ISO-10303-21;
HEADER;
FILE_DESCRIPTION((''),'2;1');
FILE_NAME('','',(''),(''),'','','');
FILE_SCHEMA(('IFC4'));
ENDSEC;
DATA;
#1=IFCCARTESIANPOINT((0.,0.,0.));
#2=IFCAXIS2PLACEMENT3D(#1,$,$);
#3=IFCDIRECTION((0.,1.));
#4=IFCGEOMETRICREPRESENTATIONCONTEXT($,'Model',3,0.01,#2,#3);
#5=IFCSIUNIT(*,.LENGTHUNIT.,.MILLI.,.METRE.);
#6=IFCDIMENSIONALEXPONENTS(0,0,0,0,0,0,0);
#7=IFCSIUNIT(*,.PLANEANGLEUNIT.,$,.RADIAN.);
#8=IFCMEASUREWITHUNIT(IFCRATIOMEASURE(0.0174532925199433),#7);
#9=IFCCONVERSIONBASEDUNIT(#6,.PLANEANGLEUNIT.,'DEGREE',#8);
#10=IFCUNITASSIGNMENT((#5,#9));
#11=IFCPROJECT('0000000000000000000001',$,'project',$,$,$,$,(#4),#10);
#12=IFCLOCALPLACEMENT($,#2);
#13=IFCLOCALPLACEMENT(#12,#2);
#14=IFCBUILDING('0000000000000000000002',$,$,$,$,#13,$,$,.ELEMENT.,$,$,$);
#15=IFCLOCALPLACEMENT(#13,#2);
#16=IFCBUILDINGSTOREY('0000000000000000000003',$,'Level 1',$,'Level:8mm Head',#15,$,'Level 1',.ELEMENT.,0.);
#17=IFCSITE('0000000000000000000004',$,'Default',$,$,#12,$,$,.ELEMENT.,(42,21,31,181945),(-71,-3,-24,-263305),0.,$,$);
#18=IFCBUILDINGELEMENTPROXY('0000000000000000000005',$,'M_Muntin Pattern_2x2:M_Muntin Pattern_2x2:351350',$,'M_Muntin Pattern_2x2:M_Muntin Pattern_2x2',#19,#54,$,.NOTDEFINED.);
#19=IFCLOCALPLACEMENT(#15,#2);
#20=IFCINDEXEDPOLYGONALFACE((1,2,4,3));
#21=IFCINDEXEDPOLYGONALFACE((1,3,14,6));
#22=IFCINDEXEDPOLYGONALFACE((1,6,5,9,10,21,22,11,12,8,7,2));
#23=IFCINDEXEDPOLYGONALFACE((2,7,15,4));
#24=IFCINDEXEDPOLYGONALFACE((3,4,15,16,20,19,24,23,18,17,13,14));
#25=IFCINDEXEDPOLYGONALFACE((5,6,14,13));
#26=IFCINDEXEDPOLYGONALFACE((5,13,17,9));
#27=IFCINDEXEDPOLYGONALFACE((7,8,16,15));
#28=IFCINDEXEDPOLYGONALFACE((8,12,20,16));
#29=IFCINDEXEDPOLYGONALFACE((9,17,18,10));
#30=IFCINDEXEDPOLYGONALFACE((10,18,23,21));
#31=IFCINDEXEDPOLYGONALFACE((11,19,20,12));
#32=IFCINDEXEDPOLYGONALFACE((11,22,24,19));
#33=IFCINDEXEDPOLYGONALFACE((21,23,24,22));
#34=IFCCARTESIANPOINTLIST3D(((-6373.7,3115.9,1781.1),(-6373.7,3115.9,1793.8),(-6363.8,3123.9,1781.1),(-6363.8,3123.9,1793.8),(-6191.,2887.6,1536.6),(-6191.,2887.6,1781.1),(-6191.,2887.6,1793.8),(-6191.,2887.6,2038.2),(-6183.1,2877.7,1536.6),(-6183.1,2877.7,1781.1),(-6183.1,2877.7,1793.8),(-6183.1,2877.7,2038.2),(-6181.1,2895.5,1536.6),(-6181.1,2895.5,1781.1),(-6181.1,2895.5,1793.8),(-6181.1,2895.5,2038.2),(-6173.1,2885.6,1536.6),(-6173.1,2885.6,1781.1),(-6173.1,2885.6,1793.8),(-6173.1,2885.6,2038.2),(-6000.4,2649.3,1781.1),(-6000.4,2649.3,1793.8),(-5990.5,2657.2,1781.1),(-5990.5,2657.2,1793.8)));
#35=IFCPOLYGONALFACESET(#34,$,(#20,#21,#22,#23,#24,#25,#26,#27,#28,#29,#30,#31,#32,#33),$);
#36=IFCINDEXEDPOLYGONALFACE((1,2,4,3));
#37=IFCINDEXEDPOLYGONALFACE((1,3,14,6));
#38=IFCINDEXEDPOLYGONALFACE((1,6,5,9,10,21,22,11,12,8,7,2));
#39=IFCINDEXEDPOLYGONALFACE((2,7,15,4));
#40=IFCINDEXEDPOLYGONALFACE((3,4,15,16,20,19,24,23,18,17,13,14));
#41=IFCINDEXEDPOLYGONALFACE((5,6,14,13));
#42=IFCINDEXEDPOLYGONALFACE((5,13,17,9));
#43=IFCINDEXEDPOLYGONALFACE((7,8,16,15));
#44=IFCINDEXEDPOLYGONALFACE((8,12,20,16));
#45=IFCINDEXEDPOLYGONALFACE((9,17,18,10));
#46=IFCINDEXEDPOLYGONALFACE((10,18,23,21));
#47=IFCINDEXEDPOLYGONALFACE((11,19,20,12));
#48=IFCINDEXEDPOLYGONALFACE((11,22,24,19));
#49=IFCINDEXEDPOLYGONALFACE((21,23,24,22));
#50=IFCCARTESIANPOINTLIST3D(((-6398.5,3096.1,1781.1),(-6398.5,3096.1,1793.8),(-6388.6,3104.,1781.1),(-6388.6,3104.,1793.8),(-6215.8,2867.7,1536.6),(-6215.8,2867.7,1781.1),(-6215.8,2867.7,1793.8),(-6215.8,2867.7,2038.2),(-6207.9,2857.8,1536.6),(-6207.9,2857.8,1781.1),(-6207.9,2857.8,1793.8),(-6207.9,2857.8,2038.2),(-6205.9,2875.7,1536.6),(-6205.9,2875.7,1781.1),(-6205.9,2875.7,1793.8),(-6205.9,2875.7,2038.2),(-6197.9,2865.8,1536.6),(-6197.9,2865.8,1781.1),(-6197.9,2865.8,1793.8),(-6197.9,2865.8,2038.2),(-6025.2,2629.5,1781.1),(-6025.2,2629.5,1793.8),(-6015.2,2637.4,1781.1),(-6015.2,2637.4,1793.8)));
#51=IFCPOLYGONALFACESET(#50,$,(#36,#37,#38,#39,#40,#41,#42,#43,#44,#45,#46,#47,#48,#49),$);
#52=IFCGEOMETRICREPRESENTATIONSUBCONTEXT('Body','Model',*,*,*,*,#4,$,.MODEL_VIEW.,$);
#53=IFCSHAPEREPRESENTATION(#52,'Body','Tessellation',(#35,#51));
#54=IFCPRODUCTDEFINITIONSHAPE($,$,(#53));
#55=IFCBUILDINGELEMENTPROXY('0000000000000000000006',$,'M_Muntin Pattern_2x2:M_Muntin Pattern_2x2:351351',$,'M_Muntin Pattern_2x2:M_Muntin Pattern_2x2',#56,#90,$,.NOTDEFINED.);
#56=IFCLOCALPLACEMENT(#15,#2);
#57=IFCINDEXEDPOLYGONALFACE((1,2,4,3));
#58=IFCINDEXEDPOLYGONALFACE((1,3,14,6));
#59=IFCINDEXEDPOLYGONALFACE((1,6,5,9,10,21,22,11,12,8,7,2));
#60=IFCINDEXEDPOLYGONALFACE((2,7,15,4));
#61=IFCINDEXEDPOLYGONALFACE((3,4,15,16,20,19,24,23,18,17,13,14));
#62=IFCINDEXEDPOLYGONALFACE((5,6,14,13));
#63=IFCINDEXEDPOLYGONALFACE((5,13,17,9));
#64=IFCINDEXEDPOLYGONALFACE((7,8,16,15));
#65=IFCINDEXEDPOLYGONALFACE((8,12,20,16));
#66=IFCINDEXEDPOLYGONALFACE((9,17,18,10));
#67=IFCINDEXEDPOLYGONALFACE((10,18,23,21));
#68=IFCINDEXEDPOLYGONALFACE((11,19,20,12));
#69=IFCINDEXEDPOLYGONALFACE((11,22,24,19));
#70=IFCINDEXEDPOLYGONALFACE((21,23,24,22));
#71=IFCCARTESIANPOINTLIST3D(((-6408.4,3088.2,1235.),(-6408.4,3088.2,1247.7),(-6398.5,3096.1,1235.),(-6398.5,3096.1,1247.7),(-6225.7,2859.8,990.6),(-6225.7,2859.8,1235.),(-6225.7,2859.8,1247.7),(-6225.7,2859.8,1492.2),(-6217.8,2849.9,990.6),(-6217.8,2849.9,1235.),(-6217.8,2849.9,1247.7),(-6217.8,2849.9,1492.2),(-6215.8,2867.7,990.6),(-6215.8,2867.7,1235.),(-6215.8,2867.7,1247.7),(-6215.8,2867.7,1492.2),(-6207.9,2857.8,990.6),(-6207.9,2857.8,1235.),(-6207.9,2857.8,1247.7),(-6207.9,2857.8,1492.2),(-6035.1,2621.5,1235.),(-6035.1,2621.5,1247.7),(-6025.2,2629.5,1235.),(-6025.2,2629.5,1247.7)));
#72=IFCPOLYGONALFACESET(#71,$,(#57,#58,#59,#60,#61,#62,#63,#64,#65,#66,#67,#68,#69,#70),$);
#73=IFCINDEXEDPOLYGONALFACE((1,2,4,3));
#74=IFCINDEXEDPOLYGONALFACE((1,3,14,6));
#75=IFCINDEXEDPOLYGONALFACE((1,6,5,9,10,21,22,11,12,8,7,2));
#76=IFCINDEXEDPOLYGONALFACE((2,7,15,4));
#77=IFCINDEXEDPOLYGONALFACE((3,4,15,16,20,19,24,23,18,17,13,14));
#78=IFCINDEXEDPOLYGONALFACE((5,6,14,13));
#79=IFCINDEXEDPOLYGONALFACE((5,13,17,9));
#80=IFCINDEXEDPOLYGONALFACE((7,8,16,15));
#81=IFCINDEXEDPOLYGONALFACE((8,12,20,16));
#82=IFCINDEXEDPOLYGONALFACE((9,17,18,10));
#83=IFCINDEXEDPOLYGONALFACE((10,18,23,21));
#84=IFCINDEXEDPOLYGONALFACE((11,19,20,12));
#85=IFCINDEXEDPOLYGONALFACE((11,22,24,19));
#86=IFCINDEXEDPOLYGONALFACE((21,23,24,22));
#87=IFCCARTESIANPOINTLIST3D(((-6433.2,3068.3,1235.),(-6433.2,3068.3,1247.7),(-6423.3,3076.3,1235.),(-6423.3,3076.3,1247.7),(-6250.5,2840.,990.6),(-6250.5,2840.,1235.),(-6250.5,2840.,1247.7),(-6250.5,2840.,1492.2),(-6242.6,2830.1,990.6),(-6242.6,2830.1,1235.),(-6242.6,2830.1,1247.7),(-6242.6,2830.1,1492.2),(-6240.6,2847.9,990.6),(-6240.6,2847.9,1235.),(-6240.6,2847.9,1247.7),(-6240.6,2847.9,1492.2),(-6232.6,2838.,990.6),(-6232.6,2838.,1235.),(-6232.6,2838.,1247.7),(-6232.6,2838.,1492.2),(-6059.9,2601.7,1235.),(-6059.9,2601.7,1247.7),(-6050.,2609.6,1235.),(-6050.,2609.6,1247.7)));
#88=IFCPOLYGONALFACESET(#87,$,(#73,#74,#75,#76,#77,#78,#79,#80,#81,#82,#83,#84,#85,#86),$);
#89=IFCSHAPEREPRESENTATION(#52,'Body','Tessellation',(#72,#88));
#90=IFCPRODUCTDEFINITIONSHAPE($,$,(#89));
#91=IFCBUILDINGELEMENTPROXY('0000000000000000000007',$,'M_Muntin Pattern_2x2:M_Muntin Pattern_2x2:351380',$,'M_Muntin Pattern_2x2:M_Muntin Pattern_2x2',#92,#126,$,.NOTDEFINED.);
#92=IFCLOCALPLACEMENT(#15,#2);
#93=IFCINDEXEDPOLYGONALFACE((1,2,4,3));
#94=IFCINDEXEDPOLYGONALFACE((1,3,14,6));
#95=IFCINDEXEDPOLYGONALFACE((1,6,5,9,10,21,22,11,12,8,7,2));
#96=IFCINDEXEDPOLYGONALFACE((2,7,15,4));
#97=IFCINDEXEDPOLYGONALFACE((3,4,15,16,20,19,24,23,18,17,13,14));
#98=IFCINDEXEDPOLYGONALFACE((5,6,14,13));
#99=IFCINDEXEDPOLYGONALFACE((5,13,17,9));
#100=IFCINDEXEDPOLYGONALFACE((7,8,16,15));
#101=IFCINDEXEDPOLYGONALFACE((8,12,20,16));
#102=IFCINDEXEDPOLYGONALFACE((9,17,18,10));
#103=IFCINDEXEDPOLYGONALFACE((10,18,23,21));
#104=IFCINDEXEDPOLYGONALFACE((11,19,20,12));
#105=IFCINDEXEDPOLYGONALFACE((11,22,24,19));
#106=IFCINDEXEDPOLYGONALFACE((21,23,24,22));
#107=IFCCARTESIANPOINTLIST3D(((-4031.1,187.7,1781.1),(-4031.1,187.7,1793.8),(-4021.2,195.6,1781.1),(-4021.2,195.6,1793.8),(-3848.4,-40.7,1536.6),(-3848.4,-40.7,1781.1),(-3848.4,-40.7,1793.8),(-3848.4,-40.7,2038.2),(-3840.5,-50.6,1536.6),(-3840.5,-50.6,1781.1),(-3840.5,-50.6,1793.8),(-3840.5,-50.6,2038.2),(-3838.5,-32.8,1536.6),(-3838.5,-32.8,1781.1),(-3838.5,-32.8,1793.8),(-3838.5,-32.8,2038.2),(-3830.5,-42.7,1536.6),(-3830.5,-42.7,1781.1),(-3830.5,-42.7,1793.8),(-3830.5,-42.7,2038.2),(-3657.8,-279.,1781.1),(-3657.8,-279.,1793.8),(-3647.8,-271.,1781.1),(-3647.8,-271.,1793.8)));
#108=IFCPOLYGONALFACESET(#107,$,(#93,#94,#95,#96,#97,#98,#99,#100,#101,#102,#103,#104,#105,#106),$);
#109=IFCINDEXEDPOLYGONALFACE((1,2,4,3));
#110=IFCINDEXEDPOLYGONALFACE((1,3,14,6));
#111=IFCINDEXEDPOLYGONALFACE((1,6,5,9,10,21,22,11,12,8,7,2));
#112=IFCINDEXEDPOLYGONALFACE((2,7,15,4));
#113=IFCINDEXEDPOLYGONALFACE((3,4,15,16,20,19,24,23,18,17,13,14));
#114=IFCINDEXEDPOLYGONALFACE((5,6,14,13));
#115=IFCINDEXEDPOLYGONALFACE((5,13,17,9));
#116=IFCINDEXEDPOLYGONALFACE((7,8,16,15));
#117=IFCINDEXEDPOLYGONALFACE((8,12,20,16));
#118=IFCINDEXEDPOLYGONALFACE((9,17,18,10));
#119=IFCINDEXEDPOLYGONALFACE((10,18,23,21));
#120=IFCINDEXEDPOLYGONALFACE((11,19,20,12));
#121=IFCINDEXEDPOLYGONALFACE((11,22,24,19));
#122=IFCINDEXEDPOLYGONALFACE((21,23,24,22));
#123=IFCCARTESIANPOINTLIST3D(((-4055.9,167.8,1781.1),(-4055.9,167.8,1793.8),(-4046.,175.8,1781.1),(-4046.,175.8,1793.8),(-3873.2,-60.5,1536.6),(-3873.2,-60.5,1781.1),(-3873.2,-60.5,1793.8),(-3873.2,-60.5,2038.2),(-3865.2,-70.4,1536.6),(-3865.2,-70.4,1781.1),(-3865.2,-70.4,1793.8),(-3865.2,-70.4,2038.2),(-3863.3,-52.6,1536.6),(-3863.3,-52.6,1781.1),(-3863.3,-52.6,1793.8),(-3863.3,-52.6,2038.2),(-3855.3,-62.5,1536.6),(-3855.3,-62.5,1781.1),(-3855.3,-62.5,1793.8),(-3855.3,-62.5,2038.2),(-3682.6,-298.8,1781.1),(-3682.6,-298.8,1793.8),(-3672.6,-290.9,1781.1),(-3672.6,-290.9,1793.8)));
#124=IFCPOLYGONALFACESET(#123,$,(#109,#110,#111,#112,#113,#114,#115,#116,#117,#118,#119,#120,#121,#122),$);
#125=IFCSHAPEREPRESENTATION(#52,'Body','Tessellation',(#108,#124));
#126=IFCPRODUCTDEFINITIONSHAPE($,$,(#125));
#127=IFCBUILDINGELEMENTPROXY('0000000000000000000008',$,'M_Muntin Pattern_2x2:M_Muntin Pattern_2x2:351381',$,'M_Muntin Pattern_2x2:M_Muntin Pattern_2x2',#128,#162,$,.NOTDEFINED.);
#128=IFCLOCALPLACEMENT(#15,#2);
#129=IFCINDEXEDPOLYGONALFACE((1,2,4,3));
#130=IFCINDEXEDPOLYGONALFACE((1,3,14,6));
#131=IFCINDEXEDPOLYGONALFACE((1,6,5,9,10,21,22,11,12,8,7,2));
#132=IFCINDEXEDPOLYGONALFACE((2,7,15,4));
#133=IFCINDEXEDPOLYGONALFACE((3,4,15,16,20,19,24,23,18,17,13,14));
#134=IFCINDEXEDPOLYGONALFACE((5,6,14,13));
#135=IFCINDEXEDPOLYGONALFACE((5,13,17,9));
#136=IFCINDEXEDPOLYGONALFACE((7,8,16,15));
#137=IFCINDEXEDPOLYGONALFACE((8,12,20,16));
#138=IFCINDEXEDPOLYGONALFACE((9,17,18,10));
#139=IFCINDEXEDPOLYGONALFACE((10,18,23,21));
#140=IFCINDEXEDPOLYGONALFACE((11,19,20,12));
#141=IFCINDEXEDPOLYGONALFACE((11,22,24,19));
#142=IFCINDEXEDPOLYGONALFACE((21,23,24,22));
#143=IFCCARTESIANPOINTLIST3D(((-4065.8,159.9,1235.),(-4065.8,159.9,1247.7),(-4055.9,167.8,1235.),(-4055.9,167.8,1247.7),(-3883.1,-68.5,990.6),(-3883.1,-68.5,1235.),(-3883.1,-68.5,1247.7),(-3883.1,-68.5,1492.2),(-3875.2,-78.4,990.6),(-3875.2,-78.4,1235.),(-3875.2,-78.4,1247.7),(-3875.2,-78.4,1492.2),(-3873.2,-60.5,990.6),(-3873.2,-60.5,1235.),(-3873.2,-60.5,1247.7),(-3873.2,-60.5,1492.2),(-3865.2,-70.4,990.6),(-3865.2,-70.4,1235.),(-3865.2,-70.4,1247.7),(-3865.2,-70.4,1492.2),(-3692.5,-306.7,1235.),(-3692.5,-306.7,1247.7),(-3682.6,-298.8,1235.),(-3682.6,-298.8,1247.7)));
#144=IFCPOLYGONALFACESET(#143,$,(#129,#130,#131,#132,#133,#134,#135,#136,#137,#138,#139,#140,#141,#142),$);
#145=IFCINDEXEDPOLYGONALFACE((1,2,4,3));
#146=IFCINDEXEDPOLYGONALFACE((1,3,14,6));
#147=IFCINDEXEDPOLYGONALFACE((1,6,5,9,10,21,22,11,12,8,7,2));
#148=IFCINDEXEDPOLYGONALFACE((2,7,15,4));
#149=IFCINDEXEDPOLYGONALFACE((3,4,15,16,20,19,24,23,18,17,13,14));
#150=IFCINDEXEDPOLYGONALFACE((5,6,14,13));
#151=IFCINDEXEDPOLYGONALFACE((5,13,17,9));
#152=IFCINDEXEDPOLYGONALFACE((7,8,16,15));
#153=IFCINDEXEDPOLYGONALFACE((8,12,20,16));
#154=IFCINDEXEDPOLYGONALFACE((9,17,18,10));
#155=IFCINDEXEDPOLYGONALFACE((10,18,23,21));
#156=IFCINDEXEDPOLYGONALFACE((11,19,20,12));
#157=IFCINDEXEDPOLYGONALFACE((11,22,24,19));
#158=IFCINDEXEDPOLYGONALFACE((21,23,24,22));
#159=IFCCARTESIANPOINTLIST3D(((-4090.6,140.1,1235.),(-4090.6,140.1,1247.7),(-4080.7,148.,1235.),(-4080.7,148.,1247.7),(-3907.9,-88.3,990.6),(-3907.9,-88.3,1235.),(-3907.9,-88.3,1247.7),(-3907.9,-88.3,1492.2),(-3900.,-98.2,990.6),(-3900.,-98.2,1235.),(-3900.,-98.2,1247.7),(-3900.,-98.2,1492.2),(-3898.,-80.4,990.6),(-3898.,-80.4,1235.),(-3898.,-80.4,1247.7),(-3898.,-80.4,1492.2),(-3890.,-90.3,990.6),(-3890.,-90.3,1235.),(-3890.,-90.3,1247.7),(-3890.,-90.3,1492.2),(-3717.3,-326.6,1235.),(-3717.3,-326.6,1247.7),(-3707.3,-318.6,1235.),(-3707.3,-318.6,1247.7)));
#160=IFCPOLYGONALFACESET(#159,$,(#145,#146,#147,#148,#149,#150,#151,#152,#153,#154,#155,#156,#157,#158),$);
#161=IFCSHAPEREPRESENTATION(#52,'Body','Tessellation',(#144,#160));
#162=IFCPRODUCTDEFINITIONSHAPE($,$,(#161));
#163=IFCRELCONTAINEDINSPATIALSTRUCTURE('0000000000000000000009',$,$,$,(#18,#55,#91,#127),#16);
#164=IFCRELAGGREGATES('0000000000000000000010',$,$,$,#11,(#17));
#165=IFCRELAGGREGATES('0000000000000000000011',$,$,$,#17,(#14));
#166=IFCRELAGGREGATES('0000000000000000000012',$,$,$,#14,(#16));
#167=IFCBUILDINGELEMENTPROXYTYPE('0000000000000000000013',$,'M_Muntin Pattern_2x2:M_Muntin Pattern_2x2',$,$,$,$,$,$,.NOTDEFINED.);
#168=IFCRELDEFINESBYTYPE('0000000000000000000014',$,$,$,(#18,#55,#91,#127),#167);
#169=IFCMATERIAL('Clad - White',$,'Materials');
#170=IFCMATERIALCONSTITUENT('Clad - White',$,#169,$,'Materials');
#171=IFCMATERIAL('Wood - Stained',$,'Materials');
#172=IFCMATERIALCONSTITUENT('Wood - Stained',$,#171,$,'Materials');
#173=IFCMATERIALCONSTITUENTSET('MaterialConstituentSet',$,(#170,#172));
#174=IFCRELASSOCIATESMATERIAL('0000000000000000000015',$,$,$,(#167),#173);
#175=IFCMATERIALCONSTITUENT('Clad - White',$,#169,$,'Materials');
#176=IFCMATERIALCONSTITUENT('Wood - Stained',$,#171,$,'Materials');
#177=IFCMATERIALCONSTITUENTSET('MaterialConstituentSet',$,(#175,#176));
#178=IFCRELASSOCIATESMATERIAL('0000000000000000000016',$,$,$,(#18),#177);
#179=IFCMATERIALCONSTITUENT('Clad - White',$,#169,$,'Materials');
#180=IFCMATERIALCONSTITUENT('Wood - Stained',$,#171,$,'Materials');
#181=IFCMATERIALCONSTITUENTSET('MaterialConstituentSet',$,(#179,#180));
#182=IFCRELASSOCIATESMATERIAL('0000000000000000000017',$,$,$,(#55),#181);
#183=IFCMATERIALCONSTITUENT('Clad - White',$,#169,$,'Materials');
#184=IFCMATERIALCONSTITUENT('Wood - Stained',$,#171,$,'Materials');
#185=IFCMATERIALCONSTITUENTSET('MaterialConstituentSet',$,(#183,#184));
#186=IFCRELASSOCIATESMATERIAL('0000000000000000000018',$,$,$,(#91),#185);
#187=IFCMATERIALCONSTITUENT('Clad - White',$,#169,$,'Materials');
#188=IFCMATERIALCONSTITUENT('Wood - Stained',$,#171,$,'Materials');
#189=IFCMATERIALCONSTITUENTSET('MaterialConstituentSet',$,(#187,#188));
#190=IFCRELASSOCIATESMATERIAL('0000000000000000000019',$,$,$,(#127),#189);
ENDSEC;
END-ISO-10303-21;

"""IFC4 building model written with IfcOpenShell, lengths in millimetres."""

from ifc_helpers import new_model, entity, si_unit, converted_unit, direction, frame, origin, place, context, subcontext, project, spatial, polyline, outline, extrude, source, transform, mapped, material, constituent, constituent_set, type_object, type_shapes, element, save


model = new_model("IFC4")

# Units and contexts
model_context = context("Model", 3, precision=0.01, world=origin(), true_north=direction((0.0, 1.0)))
body_context = subcontext(model_context, "Body", "Model", "MODEL_VIEW")
ifc_project = project(units=[si_unit("LENGTHUNIT", "METRE", prefix="MILLI"), converted_unit("PLANEANGLEUNIT", "DEGREE", entity("IfcRatioMeasure", 0.0174532925199433), si_unit("PLANEANGLEUNIT", "RADIAN"), dimensions=[0, 0, 0, 0, 0, 0, 0])], contexts=[model_context])

# Site, building, storey
site_placement = place(None, origin())
site = spatial("IfcSite", under=ifc_project, at=site_placement, Name="Default", CompositionType="ELEMENT", RefLatitude=(42, 21, 31, 181945), RefLongitude=(-71, -3, -24, -263305), RefElevation=0.0)
building_placement = place(site_placement, origin())
building = spatial("IfcBuilding", under=site, at=building_placement, CompositionType="ELEMENT")
storey_placement = place(building_placement, origin())
storey = spatial("IfcBuildingStorey", under=building, at=storey_placement, Name="Level 1", ObjectType="Level:8mm Head", LongName="Level 1", CompositionType="ELEMENT", Elevation=0.0)

# Shared definitions
ifc_material_1 = material(Name="Wood - Stained", Category="Materials")

# Building element proxies
ifc_material_2 = material(Name="Clad - White", Category="Materials")
ifc_constituent_1 = constituent(ifc_material_2, Name="Clad - White", Category="Materials")
ifc_constituent_2 = constituent(ifc_material_1, Name="Wood - Stained", Category="Materials")
ifc_constituent_set_1 = constituent_set(constituents=[ifc_constituent_1, ifc_constituent_2], Name="MaterialConstituentSet")
building_element_proxy_type_1 = type_object("IfcBuildingElementProxyType", Name="M_Muntin Pattern_2x2:M_Muntin Pattern_2x2", PredefinedType="NOTDEFINED", material=ifc_constituent_set_1)
shared_shape_1 = source(origin(), body_context, "Body", "SweptSolid", [
    extrude(outline(polyline([(6.4, -6.4), (250.8, -6.4), (250.8, 6.3), (6.4, 6.3), (6.4, 298.8), (-6.3, 298.8), (-6.3, 6.3), (-250.8, 6.3), (-250.8, -6.4), (-6.3, -6.4), (-6.3, -298.8), (6.4, -298.8), (6.4, -6.4)])), frame((0.0, 9.5, 250.8), z_axis=(0.0, 1.0, 0.0), x_axis=(0.0, 0.0, 1.0)), (0.0, 0.0, 1.0), 12.7),
    extrude(outline(polyline([(6.4, -6.4), (250.8, -6.4), (250.8, 6.3), (6.4, 6.3), (6.4, 298.8), (-6.3, 298.8), (-6.3, 6.3), (-250.8, 6.3), (-250.8, -6.4), (-6.3, -6.4), (-6.3, -298.8), (6.4, -298.8), (6.4, -6.4)])), frame((0.0, -22.2, 250.8), z_axis=(0.0, 1.0, 0.0), x_axis=(0.0, 0.0, 1.0)), (0.0, 0.0, 1.0), 12.7),
])
type_shapes(building_element_proxy_type_1, [shared_shape_1])
ifc_constituent_3 = constituent(ifc_material_2, Name="Clad - White", Category="Materials")
ifc_constituent_4 = constituent(ifc_material_1, Name="Wood - Stained", Category="Materials")
ifc_constituent_set_2 = constituent_set(constituents=[ifc_constituent_3, ifc_constituent_4], Name="MaterialConstituentSet")
proxy_1_placement = place(storey_placement, frame((-6194.5, 2876.7, 1536.6), z_axis=(0.0, 0.0, 1.0), x_axis=(0.624695, -0.780869, 0.0)))
element("IfcBuildingElementProxy", 1, at=proxy_1_placement, inside=storey, type_object=building_element_proxy_type_1, material=ifc_constituent_set_2, Name="M_Muntin Pattern_2x2:M_Muntin Pattern_2x2:351350", ObjectType="M_Muntin Pattern_2x2:M_Muntin Pattern_2x2", PredefinedType="NOTDEFINED", context=body_context, shape_type="MappedRepresentation", body=[
    mapped(shared_shape_1, transform((0.0, 0.0, 0.0), scale=1.0)),
])
ifc_constituent_5 = constituent(ifc_material_2, Name="Clad - White", Category="Materials")
ifc_constituent_6 = constituent(ifc_material_1, Name="Wood - Stained", Category="Materials")
ifc_constituent_set_3 = constituent_set(constituents=[ifc_constituent_5, ifc_constituent_6], Name="MaterialConstituentSet")
proxy_2_placement = place(storey_placement, frame((-6229.2, 2848.9, 990.6), z_axis=(0.0, 0.0, 1.0), x_axis=(0.624695, -0.780869, 0.0)))
element("IfcBuildingElementProxy", 2, at=proxy_2_placement, inside=storey, type_object=building_element_proxy_type_1, material=ifc_constituent_set_3, Name="M_Muntin Pattern_2x2:M_Muntin Pattern_2x2:351351", ObjectType="M_Muntin Pattern_2x2:M_Muntin Pattern_2x2", PredefinedType="NOTDEFINED", context=body_context, shape_type="MappedRepresentation", body=[
    mapped(shared_shape_1, transform((0.0, 0.0, 0.0), scale=1.0)),
])
ifc_constituent_7 = constituent(ifc_material_2, Name="Clad - White", Category="Materials")
ifc_constituent_8 = constituent(ifc_material_1, Name="Wood - Stained", Category="Materials")
ifc_constituent_set_4 = constituent_set(constituents=[ifc_constituent_7, ifc_constituent_8], Name="MaterialConstituentSet")
proxy_3_placement = place(storey_placement, frame((-3851.9, -51.6, 1536.6), z_axis=(0.0, 0.0, 1.0), x_axis=(0.624695, -0.780869, 0.0)))
element("IfcBuildingElementProxy", 3, at=proxy_3_placement, inside=storey, type_object=building_element_proxy_type_1, material=ifc_constituent_set_4, Name="M_Muntin Pattern_2x2:M_Muntin Pattern_2x2:351380", ObjectType="M_Muntin Pattern_2x2:M_Muntin Pattern_2x2", PredefinedType="NOTDEFINED", context=body_context, shape_type="MappedRepresentation", body=[
    mapped(shared_shape_1, transform((0.0, 0.0, 0.0), scale=1.0)),
])
ifc_constituent_9 = constituent(ifc_material_2, Name="Clad - White", Category="Materials")
ifc_constituent_10 = constituent(ifc_material_1, Name="Wood - Stained", Category="Materials")
ifc_constituent_set_5 = constituent_set(constituents=[ifc_constituent_9, ifc_constituent_10], Name="MaterialConstituentSet")
proxy_4_placement = place(storey_placement, frame((-3886.6, -79.4, 990.6), z_axis=(0.0, 0.0, 1.0), x_axis=(0.624695, -0.780869, 0.0)))
element("IfcBuildingElementProxy", 4, at=proxy_4_placement, inside=storey, type_object=building_element_proxy_type_1, material=ifc_constituent_set_5, Name="M_Muntin Pattern_2x2:M_Muntin Pattern_2x2:351381", ObjectType="M_Muntin Pattern_2x2:M_Muntin Pattern_2x2", PredefinedType="NOTDEFINED", context=body_context, shape_type="MappedRepresentation", body=[
    mapped(shared_shape_1, transform((0.0, 0.0, 0.0), scale=1.0)),
])

save(model, "model.ifc")
